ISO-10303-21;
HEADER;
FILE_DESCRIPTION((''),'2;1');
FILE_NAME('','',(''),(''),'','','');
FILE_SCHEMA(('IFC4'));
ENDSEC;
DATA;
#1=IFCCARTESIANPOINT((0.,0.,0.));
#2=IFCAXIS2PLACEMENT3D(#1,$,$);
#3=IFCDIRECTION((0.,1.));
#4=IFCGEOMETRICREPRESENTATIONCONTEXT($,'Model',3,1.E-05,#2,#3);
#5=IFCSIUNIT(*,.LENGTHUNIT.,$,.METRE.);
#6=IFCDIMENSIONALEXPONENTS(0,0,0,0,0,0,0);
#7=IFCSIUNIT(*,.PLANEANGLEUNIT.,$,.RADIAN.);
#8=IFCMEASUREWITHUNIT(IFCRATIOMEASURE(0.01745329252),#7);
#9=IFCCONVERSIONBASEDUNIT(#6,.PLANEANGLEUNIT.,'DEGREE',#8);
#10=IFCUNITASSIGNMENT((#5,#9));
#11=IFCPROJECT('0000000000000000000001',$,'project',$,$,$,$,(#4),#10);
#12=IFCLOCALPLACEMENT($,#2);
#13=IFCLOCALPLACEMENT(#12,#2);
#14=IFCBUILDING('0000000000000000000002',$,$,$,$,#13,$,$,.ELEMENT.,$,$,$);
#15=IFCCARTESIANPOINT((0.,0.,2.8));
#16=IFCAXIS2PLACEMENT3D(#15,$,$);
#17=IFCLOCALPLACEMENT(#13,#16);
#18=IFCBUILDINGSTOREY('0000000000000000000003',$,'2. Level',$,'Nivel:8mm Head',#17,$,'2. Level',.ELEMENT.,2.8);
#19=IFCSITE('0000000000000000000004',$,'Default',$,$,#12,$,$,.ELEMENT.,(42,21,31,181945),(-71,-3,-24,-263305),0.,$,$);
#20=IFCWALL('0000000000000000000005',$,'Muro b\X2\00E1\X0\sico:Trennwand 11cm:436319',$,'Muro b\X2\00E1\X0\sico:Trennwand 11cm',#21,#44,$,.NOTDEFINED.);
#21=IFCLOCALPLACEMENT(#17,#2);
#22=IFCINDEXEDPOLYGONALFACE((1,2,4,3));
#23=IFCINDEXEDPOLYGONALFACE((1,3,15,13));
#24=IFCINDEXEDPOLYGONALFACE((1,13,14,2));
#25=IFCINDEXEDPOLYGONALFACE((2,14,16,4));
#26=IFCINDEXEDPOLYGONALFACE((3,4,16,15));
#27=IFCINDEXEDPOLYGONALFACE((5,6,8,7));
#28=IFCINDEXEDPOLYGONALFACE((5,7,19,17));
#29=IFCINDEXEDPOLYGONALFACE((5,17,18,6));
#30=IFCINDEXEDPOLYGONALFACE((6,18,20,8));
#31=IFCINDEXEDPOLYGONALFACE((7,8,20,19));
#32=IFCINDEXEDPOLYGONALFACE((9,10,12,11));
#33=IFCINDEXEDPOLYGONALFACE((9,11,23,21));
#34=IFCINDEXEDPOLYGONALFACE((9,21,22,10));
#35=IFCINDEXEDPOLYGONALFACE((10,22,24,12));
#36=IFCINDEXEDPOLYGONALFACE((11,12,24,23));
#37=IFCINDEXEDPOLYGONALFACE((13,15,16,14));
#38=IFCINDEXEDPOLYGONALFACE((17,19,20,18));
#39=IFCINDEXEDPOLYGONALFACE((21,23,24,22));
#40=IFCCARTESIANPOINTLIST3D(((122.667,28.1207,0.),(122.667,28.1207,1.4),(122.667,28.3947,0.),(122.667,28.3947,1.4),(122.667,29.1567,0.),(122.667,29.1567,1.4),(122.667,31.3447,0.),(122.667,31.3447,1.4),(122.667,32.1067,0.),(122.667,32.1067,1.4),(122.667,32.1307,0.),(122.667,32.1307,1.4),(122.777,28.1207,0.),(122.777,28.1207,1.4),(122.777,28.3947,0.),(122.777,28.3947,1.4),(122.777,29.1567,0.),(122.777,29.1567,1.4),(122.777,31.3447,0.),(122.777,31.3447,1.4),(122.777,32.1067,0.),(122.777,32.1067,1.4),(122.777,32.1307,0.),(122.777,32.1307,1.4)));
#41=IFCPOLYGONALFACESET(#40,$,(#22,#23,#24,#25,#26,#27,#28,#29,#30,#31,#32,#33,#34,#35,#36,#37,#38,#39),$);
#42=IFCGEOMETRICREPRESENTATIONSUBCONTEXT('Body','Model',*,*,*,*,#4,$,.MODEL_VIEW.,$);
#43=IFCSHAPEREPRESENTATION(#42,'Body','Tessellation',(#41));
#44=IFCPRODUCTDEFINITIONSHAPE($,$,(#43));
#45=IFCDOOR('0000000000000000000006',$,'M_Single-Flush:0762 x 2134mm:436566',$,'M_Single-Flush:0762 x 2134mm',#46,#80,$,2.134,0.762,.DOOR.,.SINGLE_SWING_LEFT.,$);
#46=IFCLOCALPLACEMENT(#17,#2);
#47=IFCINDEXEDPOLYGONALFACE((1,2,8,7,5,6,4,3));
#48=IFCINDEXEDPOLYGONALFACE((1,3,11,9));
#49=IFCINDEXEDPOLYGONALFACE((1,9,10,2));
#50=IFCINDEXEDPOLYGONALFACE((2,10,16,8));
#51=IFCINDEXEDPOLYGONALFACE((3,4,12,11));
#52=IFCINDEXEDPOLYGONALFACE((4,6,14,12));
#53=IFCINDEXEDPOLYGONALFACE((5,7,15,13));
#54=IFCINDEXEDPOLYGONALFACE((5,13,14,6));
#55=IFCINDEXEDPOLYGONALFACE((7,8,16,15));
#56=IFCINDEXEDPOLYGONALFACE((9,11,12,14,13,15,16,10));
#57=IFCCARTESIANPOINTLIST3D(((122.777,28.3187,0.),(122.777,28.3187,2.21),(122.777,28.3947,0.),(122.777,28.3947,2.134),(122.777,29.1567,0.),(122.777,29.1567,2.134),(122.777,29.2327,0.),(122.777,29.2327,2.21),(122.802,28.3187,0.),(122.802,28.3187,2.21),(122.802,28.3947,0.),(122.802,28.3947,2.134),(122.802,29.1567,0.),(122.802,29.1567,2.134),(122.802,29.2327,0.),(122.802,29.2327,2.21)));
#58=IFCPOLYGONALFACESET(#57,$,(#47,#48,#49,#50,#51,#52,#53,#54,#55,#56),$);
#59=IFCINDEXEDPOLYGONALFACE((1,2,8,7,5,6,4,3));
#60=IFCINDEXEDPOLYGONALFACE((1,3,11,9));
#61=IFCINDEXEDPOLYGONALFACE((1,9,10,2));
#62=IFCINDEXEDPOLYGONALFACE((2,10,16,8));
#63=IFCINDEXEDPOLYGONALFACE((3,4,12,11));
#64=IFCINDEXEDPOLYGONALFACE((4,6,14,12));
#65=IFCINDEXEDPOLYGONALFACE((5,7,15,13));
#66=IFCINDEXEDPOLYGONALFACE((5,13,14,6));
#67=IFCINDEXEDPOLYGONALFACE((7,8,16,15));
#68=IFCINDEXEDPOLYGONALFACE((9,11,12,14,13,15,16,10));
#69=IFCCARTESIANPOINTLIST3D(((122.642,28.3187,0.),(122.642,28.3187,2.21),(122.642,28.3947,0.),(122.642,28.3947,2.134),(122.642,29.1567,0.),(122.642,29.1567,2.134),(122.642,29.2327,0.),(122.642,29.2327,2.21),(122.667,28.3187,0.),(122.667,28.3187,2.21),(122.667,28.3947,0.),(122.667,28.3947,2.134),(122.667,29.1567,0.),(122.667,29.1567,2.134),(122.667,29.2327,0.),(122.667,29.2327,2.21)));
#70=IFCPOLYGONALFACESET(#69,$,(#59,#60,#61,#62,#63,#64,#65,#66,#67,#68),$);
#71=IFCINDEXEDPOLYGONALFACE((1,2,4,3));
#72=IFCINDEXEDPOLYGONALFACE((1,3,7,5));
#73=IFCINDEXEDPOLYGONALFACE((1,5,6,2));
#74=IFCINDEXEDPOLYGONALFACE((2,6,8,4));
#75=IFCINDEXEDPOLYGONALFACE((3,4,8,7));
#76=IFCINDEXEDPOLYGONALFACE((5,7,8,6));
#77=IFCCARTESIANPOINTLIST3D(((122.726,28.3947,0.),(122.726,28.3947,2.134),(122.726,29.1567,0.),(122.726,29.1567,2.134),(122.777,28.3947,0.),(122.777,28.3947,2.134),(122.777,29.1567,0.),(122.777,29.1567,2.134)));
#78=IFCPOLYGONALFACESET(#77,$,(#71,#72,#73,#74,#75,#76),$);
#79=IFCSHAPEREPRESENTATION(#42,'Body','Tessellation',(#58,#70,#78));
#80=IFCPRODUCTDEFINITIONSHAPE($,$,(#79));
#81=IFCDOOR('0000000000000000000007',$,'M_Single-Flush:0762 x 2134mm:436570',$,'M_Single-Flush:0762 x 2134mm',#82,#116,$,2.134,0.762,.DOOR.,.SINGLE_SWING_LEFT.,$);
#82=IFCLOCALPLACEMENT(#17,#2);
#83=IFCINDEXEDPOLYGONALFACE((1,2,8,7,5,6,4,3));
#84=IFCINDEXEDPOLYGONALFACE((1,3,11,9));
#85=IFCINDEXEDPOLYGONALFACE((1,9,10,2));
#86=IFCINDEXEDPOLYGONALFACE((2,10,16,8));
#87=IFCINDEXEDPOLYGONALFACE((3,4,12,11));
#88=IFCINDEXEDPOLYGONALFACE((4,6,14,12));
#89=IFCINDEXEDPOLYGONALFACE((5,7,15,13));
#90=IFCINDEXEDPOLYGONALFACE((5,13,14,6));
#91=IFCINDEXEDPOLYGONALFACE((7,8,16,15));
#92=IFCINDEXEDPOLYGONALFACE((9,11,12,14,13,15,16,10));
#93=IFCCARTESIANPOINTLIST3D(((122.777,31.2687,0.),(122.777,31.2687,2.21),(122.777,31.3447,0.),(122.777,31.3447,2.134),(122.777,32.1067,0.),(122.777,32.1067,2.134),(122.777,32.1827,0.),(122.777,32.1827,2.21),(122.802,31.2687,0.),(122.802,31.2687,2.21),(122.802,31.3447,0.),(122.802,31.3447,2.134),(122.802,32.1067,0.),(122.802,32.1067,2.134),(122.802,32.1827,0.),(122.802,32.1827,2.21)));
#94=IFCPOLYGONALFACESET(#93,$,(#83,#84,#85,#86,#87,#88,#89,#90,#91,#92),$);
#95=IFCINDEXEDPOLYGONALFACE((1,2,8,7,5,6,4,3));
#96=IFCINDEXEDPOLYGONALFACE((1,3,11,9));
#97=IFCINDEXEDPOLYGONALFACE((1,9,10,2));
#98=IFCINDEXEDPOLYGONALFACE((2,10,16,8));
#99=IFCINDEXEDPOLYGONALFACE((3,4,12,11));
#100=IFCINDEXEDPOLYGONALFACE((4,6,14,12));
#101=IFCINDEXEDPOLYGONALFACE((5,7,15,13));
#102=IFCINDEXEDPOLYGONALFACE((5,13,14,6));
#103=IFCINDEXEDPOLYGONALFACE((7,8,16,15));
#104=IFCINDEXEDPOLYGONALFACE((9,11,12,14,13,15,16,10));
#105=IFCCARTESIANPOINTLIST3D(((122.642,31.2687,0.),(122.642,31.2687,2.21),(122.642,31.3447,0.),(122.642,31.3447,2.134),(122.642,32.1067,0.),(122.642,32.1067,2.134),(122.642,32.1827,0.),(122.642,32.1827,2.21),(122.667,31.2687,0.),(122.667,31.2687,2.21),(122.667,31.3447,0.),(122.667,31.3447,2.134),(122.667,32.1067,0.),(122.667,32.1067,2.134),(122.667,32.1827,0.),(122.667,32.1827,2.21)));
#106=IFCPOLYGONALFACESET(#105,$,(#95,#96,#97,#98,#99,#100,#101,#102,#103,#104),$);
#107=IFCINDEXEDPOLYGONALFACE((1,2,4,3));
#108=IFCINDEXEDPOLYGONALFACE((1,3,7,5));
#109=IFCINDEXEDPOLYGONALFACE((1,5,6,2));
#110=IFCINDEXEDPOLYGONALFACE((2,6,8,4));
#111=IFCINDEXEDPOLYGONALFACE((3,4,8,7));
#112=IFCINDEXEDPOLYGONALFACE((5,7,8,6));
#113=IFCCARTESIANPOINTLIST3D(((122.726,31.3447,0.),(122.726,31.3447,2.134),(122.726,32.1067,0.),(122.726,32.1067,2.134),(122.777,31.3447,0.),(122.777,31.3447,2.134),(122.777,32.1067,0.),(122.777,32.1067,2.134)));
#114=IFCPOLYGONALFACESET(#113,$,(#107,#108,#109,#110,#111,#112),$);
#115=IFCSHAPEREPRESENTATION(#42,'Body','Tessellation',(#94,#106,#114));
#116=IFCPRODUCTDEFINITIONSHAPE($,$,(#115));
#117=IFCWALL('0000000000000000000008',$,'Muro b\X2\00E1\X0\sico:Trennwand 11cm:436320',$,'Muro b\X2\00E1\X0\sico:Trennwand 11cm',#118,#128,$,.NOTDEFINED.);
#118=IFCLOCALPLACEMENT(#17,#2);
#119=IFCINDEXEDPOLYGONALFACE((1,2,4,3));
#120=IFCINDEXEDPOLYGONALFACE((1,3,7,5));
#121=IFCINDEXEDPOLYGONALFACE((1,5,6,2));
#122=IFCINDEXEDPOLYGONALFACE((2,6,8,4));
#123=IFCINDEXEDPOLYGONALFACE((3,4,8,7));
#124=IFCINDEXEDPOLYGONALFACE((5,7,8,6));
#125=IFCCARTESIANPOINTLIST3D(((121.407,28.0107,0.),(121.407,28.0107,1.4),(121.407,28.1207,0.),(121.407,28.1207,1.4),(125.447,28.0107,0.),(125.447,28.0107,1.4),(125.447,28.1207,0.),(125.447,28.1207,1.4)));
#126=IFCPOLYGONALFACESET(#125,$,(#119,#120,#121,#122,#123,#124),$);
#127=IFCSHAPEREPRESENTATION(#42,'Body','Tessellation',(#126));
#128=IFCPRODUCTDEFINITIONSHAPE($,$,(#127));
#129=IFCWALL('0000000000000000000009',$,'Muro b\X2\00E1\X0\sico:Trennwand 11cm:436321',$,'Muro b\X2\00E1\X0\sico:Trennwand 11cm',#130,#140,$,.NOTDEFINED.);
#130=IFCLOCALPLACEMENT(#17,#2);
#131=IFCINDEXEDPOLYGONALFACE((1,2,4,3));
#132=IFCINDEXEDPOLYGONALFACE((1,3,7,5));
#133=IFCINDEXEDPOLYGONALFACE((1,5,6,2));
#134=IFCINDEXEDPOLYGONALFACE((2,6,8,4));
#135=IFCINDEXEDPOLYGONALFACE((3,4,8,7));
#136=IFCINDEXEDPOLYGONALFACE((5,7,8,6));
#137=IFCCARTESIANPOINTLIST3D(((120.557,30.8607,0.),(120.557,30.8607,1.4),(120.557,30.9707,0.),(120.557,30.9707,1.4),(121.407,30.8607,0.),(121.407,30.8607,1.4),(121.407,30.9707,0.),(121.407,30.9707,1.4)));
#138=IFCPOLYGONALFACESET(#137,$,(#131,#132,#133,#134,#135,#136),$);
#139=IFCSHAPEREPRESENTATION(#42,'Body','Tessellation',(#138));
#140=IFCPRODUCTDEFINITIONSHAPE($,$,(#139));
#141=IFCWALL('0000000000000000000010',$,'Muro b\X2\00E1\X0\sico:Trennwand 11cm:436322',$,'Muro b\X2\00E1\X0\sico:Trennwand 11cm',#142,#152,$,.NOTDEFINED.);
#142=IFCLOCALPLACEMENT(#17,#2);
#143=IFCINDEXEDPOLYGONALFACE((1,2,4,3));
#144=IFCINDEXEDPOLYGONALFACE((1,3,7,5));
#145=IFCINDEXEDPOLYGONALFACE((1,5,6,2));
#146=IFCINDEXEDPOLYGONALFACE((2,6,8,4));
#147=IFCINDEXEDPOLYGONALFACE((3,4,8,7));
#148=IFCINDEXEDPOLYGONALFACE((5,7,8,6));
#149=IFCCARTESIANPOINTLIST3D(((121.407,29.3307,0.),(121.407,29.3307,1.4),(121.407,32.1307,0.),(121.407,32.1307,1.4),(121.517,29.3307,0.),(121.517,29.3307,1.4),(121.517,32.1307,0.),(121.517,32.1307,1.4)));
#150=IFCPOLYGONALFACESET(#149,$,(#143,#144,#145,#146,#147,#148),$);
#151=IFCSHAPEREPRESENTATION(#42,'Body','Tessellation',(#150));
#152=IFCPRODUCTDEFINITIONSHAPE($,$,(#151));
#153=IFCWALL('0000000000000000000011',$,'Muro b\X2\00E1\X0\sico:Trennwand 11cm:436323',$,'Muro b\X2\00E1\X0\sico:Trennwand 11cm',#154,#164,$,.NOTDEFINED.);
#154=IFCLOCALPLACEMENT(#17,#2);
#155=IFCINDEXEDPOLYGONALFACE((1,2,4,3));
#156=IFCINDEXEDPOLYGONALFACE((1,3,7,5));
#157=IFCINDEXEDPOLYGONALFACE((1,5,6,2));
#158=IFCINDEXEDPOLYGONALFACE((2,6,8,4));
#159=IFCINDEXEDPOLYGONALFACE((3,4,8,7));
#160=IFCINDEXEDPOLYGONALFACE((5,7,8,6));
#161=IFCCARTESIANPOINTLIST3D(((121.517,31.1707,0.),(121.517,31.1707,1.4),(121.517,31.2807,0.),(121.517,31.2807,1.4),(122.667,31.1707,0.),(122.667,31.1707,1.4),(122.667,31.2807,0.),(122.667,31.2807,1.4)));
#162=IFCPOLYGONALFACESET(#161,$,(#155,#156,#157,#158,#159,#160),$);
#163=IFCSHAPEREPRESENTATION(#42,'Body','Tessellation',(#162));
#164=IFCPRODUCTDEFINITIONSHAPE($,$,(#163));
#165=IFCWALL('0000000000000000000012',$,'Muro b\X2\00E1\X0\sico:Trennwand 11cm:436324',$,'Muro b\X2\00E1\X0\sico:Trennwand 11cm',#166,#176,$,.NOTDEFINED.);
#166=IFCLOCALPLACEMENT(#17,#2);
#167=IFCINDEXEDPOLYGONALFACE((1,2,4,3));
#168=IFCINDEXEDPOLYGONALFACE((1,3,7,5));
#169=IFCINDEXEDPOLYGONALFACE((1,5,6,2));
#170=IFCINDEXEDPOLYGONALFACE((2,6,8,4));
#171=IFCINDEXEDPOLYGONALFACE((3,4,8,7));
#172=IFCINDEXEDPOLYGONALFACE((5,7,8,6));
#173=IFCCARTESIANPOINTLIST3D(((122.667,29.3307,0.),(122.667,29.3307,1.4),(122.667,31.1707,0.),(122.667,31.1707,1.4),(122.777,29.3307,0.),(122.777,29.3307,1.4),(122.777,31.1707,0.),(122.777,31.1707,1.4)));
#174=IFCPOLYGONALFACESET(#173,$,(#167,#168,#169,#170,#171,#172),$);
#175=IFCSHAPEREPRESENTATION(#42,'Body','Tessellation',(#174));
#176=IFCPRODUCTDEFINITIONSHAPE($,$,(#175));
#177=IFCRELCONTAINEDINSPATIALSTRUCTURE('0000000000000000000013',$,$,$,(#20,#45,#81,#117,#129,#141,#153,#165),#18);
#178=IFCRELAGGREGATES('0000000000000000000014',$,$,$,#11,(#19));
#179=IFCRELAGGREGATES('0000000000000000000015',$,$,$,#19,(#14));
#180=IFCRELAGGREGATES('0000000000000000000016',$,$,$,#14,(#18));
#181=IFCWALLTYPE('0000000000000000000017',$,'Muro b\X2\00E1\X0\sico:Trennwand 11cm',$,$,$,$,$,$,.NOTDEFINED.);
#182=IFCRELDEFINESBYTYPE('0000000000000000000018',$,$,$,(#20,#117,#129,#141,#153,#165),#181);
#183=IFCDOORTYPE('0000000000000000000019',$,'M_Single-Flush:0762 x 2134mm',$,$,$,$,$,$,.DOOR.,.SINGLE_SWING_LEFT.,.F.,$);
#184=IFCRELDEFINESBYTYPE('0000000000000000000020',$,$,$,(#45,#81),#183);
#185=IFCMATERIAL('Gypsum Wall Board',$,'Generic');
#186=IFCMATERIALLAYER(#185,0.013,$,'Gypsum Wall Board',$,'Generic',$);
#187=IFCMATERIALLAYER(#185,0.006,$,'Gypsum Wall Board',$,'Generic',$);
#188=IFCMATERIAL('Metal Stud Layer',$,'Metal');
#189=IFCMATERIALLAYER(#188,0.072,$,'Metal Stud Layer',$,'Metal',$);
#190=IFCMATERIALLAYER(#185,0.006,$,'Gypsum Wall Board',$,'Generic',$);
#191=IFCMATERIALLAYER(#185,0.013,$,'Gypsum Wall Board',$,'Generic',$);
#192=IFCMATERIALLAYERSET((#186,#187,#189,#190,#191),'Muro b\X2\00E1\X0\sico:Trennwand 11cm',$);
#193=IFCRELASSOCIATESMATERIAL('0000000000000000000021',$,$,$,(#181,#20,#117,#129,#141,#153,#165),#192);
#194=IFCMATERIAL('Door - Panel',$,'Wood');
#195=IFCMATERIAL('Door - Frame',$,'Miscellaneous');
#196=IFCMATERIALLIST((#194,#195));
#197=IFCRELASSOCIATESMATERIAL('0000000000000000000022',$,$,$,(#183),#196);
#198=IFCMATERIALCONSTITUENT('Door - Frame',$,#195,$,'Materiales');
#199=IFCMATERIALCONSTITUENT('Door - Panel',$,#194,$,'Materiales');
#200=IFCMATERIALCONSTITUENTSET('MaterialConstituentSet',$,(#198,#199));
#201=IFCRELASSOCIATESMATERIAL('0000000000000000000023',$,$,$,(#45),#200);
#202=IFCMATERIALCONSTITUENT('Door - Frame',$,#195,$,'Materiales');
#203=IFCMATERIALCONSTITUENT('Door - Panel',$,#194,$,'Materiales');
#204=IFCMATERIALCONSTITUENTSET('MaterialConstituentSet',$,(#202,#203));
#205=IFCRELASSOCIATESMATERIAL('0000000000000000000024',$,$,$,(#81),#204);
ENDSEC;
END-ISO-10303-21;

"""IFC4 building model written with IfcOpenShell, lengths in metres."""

from ifc_helpers import new_model, entity, si_unit, converted_unit, direction, frame, frame_2d, origin, origin_2d_with_axis, place, context, subcontext, project, spatial, polyline, rectangle, outline, extrude, clip, halfspace, source, transform, mapped, material, material_list, layer, layer_set, layer_usage, constituent, constituent_set, type_object, type_shapes, element, fill, save


model = new_model("IFC4")

# Units and contexts
model_context = context("Model", 3, precision=1e-05, world=origin(), true_north=direction((0.0, 1.0)))
body_context = subcontext(model_context, "Body", "Model", "MODEL_VIEW")
ifc_project = project(units=[si_unit("LENGTHUNIT", "METRE"), converted_unit("PLANEANGLEUNIT", "DEGREE", entity("IfcRatioMeasure", 0.01745329252), si_unit("PLANEANGLEUNIT", "RADIAN"), dimensions=[0, 0, 0, 0, 0, 0, 0])], contexts=[model_context])

# Site, building, storey
site_placement = place(None, origin())
site = spatial("IfcSite", under=ifc_project, at=site_placement, Name="Default", CompositionType="ELEMENT", RefLatitude=(42, 21, 31, 181945), RefLongitude=(-71, -3, -24, -263305), RefElevation=0.0)
building_placement = place(site_placement, origin())
building = spatial("IfcBuilding", under=site, at=building_placement, CompositionType="ELEMENT")
storey_placement = place(building_placement, frame((0.0, 0.0, 2.8)))
storey = spatial("IfcBuildingStorey", under=building, at=storey_placement, Name="2. Level", ObjectType="Nivel:8mm Head", LongName="2. Level", CompositionType="ELEMENT", Elevation=2.8)

# Shared definitions
ifc_material_1 = material(Name="Gypsum Wall Board", Category="Generic")
ifc_layer_1 = layer(ifc_material_1, 0.013, Name="Gypsum Wall Board", Category="Generic")
ifc_layer_2 = layer(ifc_material_1, 0.006, Name="Gypsum Wall Board", Category="Generic")
ifc_material_2 = material(Name="Metal Stud Layer", Category="Metal")
ifc_layer_3 = layer(ifc_material_2, 0.072, Name="Metal Stud Layer", Category="Metal")
ifc_layer_4 = layer(ifc_material_1, 0.006, Name="Gypsum Wall Board", Category="Generic")
ifc_layer_5 = layer(ifc_material_1, 0.013, Name="Gypsum Wall Board", Category="Generic")
ifc_layer_set_1 = layer_set([ifc_layer_1, ifc_layer_2, ifc_layer_3, ifc_layer_4, ifc_layer_5], Name="Muro básico:Trennwand 11cm")
wall_type_1 = type_object("IfcWallType", Name="Muro básico:Trennwand 11cm", PredefinedType="NOTDEFINED", material=ifc_layer_set_1)
ifc_material_3 = material(Name="Door - Frame", Category="Miscellaneous")
ifc_material_4 = material(Name="Door - Panel", Category="Wood")
ifc_material_list_1 = material_list([ifc_material_4, ifc_material_3])
door_type_1 = type_object("IfcDoorType", Name="M_Single-Flush:0762 x 2134mm", OperationType="SINGLE_SWING_LEFT", ParameterTakesPrecedence=False, PredefinedType="DOOR", material=ifc_material_list_1)
shared_shape_1 = source(origin(), body_context, "Body", "SweptSolid", [
    extrude(outline(polyline([(-0.457, -1.124), (0.457, -1.124), (0.457, 1.086), (0.381, 1.086), (0.381, -1.048), (-0.381, -1.048), (-0.381, 1.086), (-0.457, 1.086), (-0.457, -1.124)])), frame((0.381, 0.135, 1.086), z_axis=(0.0, -1.0, 0.0), x_axis=(-1.0, 0.0, 0.0)), (0.0, 0.0, 1.0), 0.025),
    extrude(outline(polyline([(-1.124, -0.457), (1.086, -0.457), (1.086, -0.381), (-1.048, -0.381), (-1.048, 0.381), (1.086, 0.381), (1.086, 0.457), (-1.124, 0.457), (-1.124, -0.457)])), frame((0.381, 0.0, 1.086), z_axis=(0.0, -1.0, 0.0), x_axis=(0.0, 0.0, -1.0)), (0.0, 0.0, 1.0), 0.025),
    extrude(rectangle(XDim=0.762, YDim=0.051, at=origin_2d_with_axis()), frame((0.381, 0.0845, 0.0)), (0.0, 0.0, 1.0), 2.134),
])
type_shapes(door_type_1, [shared_shape_1])

# Wall, openings, doors
ifc_layer_usage_1 = layer_usage(ifc_layer_set_1, "AXIS2", "NEGATIVE", 0.055)
wall_1_placement = place(storey_placement, frame((122.722, 32.1307, 0.0), z_axis=(0.0, 0.0, 1.0), x_axis=(0.0, -1.0, 0.0)))
wall_1 = element("IfcWall", 1, at=wall_1_placement, inside=storey, type_object=wall_type_1, material=ifc_layer_usage_1, Name="Muro básico:Trennwand 11cm:436319", ObjectType="Muro básico:Trennwand 11cm", PredefinedType="NOTDEFINED", context=body_context, shape_type="Clipping", body=[
    clip(extrude(rectangle(XDim=4.01, YDim=0.11, at=frame_2d((2.005, 0.0), x_axis=(-1.0, 0.0))), origin(), (0.0, 0.0, 1.0), 1.4), halfspace(origin(), True)),
])
opening_1_placement = place(wall_1_placement, frame((2.974, -0.055, 0.0)))
opening_1 = element("IfcOpeningElement", 2, at=opening_1_placement, cuts=wall_1, ObjectType="Opening", PredefinedType="OPENING", context=body_context, shape_type="SweptSolid", body=[
    extrude(rectangle(XDim=0.762, YDim=2.134, at=frame_2d((1.067, 0.381), x_axis=(0.0, -1.0))), frame((0.0, 0.0, 0.0), z_axis=(0.0, 1.0, 0.0), x_axis=(0.0, 0.0, 1.0)), (0.0, 0.0, 1.0), 0.11),
])
opening_2_placement = place(wall_1_placement, frame((0.024, -0.055, 0.0)))
opening_2 = element("IfcOpeningElement", 3, at=opening_2_placement, cuts=wall_1, ObjectType="Opening", PredefinedType="OPENING", context=body_context, shape_type="SweptSolid", body=[
    extrude(rectangle(XDim=0.762, YDim=2.134, at=frame_2d((1.067, 0.381), x_axis=(0.0, -1.0))), frame((0.0, 0.0, 0.0), z_axis=(0.0, 1.0, 0.0), x_axis=(0.0, 0.0, 1.0)), (0.0, 0.0, 1.0), 0.11),
])
ifc_constituent_1 = constituent(ifc_material_3, Name="Door - Frame", Category="Materiales")
ifc_constituent_2 = constituent(ifc_material_4, Name="Door - Panel", Category="Materiales")
ifc_constituent_set_1 = constituent_set(constituents=[ifc_constituent_1, ifc_constituent_2], Name="MaterialConstituentSet")
door_1_placement = place(opening_1_placement, origin())
door_1 = element("IfcDoor", 4, at=door_1_placement, inside=storey, type_object=door_type_1, material=ifc_constituent_set_1, Name="M_Single-Flush:0762 x 2134mm:436566", ObjectType="M_Single-Flush:0762 x 2134mm", OperationType="SINGLE_SWING_LEFT", OverallHeight=2.134, OverallWidth=0.762, PredefinedType="DOOR", context=body_context, shape_type="MappedRepresentation", body=[
    mapped(shared_shape_1, transform((0.0, 0.0, 0.0), scale=1.0)),
])
fill(opening_1, door_1)
ifc_constituent_3 = constituent(ifc_material_3, Name="Door - Frame", Category="Materiales")
ifc_constituent_4 = constituent(ifc_material_4, Name="Door - Panel", Category="Materiales")
ifc_constituent_set_2 = constituent_set(constituents=[ifc_constituent_3, ifc_constituent_4], Name="MaterialConstituentSet")
door_2_placement = place(opening_2_placement, origin())
door_2 = element("IfcDoor", 5, at=door_2_placement, inside=storey, type_object=door_type_1, material=ifc_constituent_set_2, Name="M_Single-Flush:0762 x 2134mm:436570", ObjectType="M_Single-Flush:0762 x 2134mm", OperationType="SINGLE_SWING_LEFT", OverallHeight=2.134, OverallWidth=0.762, PredefinedType="DOOR", context=body_context, shape_type="MappedRepresentation", body=[
    mapped(shared_shape_1, transform((0.0, 0.0, 0.0), scale=1.0)),
])
fill(opening_2, door_2)

# Walls
ifc_layer_usage_2 = layer_usage(ifc_layer_set_1, "AXIS2", "NEGATIVE", 0.055)
wall_2_placement = place(storey_placement, frame((125.447, 28.0657, 0.0), z_axis=(0.0, 0.0, 1.0), x_axis=(-1.0, 0.0, 0.0)))
element("IfcWall", 6, at=wall_2_placement, inside=storey, type_object=wall_type_1, material=ifc_layer_usage_2, Name="Muro básico:Trennwand 11cm:436320", ObjectType="Muro básico:Trennwand 11cm", PredefinedType="NOTDEFINED", context=body_context, shape_type="Clipping", body=[
    clip(extrude(rectangle(XDim=4.04, YDim=0.11, at=frame_2d((2.02, 0.0), x_axis=(-1.0, 0.0))), origin(), (0.0, 0.0, 1.0), 1.4), halfspace(origin(), True)),
])
ifc_layer_usage_3 = layer_usage(ifc_layer_set_1, "AXIS2", "NEGATIVE", 0.055)
wall_3_placement = place(storey_placement, frame((120.557, 30.9157, 0.0)))
element("IfcWall", 7, at=wall_3_placement, inside=storey, type_object=wall_type_1, material=ifc_layer_usage_3, Name="Muro básico:Trennwand 11cm:436321", ObjectType="Muro básico:Trennwand 11cm", PredefinedType="NOTDEFINED", context=body_context, shape_type="Clipping", body=[
    clip(extrude(rectangle(XDim=0.85, YDim=0.11, at=frame_2d((0.425, 0.0), x_axis=(-1.0, 0.0))), origin(), (0.0, 0.0, 1.0), 1.4), halfspace(origin(), True)),
])
ifc_layer_usage_4 = layer_usage(ifc_layer_set_1, "AXIS2", "NEGATIVE", 0.055)
wall_4_placement = place(storey_placement, frame((121.462, 32.1307, 0.0), z_axis=(0.0, 0.0, 1.0), x_axis=(0.0, -1.0, 0.0)))
element("IfcWall", 8, at=wall_4_placement, inside=storey, type_object=wall_type_1, material=ifc_layer_usage_4, Name="Muro básico:Trennwand 11cm:436322", ObjectType="Muro básico:Trennwand 11cm", PredefinedType="NOTDEFINED", context=body_context, shape_type="Clipping", body=[
    clip(extrude(rectangle(XDim=2.8, YDim=0.11, at=frame_2d((1.4, 0.0), x_axis=(-1.0, 0.0))), origin(), (0.0, 0.0, 1.0), 1.4), halfspace(origin(), True)),
])
ifc_layer_usage_5 = layer_usage(ifc_layer_set_1, "AXIS2", "NEGATIVE", 0.055)
wall_5_placement = place(storey_placement, frame((121.517, 31.2257, 0.0)))
element("IfcWall", 9, at=wall_5_placement, inside=storey, type_object=wall_type_1, material=ifc_layer_usage_5, Name="Muro básico:Trennwand 11cm:436323", ObjectType="Muro básico:Trennwand 11cm", PredefinedType="NOTDEFINED", context=body_context, shape_type="Clipping", body=[
    clip(extrude(rectangle(XDim=1.15, YDim=0.11, at=frame_2d((0.575, 0.0), x_axis=(-1.0, 0.0))), origin(), (0.0, 0.0, 1.0), 1.4), halfspace(origin(), True)),
])
ifc_layer_usage_6 = layer_usage(ifc_layer_set_1, "AXIS2", "NEGATIVE", 0.055)
wall_6_placement = place(storey_placement, frame((122.722, 31.1707, 0.0), z_axis=(0.0, 0.0, 1.0), x_axis=(0.0, -1.0, 0.0)))
element("IfcWall", 10, at=wall_6_placement, inside=storey, type_object=wall_type_1, material=ifc_layer_usage_6, Name="Muro básico:Trennwand 11cm:436324", ObjectType="Muro básico:Trennwand 11cm", PredefinedType="NOTDEFINED", context=body_context, shape_type="Clipping", body=[
    clip(extrude(rectangle(XDim=1.84, YDim=0.11, at=frame_2d((0.92, 0.0), x_axis=(-1.0, 0.0))), origin(), (0.0, 0.0, 1.0), 1.4), halfspace(origin(), True)),
])

save(model, "model.ifc")
